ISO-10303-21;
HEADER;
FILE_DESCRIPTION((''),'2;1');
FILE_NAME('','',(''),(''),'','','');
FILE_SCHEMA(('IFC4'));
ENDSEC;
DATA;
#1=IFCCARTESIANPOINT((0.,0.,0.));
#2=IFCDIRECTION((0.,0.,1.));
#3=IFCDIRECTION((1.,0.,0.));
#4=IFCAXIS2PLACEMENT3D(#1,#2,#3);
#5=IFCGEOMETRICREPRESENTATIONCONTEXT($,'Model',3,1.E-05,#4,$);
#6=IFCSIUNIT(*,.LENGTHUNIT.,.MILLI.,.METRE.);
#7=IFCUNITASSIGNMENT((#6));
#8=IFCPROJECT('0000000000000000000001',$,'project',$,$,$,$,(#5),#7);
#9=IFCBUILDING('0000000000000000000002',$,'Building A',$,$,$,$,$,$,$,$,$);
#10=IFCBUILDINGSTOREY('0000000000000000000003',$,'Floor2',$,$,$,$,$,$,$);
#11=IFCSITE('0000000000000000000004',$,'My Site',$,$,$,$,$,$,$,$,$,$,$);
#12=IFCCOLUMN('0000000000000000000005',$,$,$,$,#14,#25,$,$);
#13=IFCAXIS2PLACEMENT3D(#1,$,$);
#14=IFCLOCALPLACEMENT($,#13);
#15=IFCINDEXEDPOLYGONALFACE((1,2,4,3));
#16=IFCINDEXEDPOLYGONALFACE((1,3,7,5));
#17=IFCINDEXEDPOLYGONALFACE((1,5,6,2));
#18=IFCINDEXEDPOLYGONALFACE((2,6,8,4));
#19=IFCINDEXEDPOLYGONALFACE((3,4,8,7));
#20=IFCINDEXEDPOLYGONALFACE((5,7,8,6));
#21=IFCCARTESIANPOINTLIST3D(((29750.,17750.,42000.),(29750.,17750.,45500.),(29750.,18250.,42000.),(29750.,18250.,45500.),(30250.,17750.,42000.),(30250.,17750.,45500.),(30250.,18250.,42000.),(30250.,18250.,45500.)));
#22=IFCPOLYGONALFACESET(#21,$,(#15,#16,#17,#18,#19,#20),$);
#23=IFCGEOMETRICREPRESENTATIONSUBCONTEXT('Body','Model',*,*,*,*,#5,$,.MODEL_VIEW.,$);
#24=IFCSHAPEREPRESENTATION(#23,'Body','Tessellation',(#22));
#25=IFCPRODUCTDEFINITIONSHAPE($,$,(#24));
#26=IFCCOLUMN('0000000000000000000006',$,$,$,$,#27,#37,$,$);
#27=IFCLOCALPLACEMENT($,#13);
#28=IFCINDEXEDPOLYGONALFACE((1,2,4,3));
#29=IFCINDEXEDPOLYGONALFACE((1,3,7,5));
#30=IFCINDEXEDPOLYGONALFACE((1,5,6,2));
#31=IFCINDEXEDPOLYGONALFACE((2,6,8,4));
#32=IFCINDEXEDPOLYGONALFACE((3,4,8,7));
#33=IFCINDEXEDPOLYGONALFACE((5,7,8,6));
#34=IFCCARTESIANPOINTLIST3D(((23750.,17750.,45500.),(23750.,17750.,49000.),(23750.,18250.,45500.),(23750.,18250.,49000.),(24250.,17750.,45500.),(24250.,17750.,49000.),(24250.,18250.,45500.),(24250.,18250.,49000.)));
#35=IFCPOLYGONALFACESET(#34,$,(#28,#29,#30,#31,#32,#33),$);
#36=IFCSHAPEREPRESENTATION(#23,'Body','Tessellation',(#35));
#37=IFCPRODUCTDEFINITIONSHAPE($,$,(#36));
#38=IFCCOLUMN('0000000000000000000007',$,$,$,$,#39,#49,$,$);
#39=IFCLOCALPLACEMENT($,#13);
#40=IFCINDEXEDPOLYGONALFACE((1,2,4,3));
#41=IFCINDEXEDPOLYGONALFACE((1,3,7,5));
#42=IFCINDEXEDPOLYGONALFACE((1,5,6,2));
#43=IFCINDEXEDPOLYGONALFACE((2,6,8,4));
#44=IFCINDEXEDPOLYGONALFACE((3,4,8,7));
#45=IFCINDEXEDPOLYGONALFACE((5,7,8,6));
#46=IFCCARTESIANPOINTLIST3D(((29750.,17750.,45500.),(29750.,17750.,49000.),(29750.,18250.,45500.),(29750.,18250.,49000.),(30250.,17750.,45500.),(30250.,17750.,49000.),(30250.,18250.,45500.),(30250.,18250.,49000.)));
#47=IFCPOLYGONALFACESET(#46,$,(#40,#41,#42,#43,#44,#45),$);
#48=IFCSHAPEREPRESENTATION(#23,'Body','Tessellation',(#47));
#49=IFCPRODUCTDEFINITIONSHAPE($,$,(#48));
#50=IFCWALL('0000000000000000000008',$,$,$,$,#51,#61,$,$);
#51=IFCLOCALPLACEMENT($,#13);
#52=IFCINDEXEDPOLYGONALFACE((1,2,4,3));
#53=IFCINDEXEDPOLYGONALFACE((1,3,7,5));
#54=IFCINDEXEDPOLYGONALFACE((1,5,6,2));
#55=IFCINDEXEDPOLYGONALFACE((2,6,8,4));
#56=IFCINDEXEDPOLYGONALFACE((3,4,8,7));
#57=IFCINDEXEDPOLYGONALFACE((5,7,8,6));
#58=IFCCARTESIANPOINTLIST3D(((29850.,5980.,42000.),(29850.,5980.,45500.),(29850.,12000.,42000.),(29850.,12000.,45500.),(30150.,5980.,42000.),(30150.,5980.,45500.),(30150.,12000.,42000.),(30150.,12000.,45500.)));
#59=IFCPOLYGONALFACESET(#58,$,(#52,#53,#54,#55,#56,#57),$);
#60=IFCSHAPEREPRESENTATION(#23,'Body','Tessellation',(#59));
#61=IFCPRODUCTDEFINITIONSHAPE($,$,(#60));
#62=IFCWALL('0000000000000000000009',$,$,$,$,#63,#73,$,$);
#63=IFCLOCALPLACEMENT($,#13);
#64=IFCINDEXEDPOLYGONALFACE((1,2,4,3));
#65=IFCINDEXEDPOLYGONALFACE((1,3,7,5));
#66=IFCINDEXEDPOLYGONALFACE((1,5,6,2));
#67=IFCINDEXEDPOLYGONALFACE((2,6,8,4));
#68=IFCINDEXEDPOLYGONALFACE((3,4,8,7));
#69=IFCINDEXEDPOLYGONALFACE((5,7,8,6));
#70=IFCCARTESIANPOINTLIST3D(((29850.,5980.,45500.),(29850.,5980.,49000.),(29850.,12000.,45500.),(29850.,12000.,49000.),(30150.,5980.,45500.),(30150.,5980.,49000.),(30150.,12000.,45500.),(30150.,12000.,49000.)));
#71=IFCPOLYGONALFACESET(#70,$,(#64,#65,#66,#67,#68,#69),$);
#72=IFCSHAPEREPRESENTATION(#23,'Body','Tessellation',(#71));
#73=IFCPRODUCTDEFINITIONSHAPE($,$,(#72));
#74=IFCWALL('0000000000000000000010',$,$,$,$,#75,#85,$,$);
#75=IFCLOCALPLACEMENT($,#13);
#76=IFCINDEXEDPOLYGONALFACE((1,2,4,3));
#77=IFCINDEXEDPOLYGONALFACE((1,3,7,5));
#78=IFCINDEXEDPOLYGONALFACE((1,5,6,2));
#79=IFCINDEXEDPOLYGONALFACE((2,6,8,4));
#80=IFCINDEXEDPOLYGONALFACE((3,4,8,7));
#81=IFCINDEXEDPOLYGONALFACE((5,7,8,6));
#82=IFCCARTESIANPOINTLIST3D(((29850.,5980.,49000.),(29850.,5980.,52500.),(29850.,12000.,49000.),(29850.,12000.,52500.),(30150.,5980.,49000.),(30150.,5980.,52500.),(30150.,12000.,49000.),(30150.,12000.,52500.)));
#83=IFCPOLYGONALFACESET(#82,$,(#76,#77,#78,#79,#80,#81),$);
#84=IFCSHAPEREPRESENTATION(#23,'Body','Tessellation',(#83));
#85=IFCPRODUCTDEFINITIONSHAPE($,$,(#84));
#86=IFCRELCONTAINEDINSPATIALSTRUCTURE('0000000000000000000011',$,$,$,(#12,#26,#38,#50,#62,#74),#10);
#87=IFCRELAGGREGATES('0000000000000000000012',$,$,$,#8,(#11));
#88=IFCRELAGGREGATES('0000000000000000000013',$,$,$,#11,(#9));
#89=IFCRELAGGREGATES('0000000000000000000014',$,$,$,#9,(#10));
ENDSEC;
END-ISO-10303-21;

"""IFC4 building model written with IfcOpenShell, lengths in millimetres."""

from ifc_helpers import new_model, si_unit, frame, origin_with_axes, place, context, subcontext, project, spatial, line, indexed_curve, outline, extrude, element, save


model = new_model("IFC4")

# Units and contexts
model_context = context("Model", 3, precision=1e-05, world=origin_with_axes())
body_context = subcontext(model_context, "Body", "Model", "MODEL_VIEW")
ifc_project = project(units=[si_unit("LENGTHUNIT", "METRE", prefix="MILLI")], contexts=[model_context])

# Site, building, storey
site = spatial("IfcSite", under=ifc_project, Name="My Site")
building = spatial("IfcBuilding", under=site, Name="Building A")
storey = spatial("IfcBuildingStorey", under=building, Name="Floor2")

# Columns
for number, where, z_axis, x_axis in (
    (1, (30000.0, 18000.0, 42000.0), (0.0, 0.0, 1.0), (1.0, 0.0, 0.0)),
    (2, (24000.0, 18000.0, 45500.0), (0.0, 0.0, 1.0), (1.0, 0.0, 0.0)),
    (3, (30000.0, 18000.0, 45500.0), (0.0, 0.0, 1.0), (1.0, 0.0, 0.0)),
):
    element("IfcColumn", number, at=place(None, frame(where, z_axis=z_axis, x_axis=x_axis)), inside=storey, context=body_context, shape_type="SweptSolid", body=[
        extrude(outline(indexed_curve([(-250.0, -250.0), (250.0, -250.0), (250.0, 250.0), (-250.0, 250.0)], segments=[line(1, 2, 3, 4, 1)])), origin_with_axes(), (0.0, 0.0, 1.0), 3500.0),
    ])

# Walls
for number, where, z_axis, x_axis in (
    (4, (29850.0, 12000.0, 42000.0), (0.0, 0.0, 1.0), (0.0, -1.0, 0.0)),
    (5, (29850.0, 12000.0, 45500.0), (0.0, 0.0, 1.0), (0.0, -1.0, 0.0)),
    (6, (29850.0, 12000.0, 49000.0), (0.0, 0.0, 1.0), (0.0, -1.0, 0.0)),
):
    element("IfcWall", number, at=place(None, frame(where, z_axis=z_axis, x_axis=x_axis)), inside=storey, context=body_context, shape_type="SweptSolid", body=[
        extrude(outline(indexed_curve([(0.0, 0.0), (0.0, 300.0), (6020.0, 300.0), (6020.0, 0.0), (0.0, 0.0)], self_intersect=False)), origin_with_axes(), (0.0, 0.0, 1.0), 3500.0),
    ])

save(model, "model.ifc")
